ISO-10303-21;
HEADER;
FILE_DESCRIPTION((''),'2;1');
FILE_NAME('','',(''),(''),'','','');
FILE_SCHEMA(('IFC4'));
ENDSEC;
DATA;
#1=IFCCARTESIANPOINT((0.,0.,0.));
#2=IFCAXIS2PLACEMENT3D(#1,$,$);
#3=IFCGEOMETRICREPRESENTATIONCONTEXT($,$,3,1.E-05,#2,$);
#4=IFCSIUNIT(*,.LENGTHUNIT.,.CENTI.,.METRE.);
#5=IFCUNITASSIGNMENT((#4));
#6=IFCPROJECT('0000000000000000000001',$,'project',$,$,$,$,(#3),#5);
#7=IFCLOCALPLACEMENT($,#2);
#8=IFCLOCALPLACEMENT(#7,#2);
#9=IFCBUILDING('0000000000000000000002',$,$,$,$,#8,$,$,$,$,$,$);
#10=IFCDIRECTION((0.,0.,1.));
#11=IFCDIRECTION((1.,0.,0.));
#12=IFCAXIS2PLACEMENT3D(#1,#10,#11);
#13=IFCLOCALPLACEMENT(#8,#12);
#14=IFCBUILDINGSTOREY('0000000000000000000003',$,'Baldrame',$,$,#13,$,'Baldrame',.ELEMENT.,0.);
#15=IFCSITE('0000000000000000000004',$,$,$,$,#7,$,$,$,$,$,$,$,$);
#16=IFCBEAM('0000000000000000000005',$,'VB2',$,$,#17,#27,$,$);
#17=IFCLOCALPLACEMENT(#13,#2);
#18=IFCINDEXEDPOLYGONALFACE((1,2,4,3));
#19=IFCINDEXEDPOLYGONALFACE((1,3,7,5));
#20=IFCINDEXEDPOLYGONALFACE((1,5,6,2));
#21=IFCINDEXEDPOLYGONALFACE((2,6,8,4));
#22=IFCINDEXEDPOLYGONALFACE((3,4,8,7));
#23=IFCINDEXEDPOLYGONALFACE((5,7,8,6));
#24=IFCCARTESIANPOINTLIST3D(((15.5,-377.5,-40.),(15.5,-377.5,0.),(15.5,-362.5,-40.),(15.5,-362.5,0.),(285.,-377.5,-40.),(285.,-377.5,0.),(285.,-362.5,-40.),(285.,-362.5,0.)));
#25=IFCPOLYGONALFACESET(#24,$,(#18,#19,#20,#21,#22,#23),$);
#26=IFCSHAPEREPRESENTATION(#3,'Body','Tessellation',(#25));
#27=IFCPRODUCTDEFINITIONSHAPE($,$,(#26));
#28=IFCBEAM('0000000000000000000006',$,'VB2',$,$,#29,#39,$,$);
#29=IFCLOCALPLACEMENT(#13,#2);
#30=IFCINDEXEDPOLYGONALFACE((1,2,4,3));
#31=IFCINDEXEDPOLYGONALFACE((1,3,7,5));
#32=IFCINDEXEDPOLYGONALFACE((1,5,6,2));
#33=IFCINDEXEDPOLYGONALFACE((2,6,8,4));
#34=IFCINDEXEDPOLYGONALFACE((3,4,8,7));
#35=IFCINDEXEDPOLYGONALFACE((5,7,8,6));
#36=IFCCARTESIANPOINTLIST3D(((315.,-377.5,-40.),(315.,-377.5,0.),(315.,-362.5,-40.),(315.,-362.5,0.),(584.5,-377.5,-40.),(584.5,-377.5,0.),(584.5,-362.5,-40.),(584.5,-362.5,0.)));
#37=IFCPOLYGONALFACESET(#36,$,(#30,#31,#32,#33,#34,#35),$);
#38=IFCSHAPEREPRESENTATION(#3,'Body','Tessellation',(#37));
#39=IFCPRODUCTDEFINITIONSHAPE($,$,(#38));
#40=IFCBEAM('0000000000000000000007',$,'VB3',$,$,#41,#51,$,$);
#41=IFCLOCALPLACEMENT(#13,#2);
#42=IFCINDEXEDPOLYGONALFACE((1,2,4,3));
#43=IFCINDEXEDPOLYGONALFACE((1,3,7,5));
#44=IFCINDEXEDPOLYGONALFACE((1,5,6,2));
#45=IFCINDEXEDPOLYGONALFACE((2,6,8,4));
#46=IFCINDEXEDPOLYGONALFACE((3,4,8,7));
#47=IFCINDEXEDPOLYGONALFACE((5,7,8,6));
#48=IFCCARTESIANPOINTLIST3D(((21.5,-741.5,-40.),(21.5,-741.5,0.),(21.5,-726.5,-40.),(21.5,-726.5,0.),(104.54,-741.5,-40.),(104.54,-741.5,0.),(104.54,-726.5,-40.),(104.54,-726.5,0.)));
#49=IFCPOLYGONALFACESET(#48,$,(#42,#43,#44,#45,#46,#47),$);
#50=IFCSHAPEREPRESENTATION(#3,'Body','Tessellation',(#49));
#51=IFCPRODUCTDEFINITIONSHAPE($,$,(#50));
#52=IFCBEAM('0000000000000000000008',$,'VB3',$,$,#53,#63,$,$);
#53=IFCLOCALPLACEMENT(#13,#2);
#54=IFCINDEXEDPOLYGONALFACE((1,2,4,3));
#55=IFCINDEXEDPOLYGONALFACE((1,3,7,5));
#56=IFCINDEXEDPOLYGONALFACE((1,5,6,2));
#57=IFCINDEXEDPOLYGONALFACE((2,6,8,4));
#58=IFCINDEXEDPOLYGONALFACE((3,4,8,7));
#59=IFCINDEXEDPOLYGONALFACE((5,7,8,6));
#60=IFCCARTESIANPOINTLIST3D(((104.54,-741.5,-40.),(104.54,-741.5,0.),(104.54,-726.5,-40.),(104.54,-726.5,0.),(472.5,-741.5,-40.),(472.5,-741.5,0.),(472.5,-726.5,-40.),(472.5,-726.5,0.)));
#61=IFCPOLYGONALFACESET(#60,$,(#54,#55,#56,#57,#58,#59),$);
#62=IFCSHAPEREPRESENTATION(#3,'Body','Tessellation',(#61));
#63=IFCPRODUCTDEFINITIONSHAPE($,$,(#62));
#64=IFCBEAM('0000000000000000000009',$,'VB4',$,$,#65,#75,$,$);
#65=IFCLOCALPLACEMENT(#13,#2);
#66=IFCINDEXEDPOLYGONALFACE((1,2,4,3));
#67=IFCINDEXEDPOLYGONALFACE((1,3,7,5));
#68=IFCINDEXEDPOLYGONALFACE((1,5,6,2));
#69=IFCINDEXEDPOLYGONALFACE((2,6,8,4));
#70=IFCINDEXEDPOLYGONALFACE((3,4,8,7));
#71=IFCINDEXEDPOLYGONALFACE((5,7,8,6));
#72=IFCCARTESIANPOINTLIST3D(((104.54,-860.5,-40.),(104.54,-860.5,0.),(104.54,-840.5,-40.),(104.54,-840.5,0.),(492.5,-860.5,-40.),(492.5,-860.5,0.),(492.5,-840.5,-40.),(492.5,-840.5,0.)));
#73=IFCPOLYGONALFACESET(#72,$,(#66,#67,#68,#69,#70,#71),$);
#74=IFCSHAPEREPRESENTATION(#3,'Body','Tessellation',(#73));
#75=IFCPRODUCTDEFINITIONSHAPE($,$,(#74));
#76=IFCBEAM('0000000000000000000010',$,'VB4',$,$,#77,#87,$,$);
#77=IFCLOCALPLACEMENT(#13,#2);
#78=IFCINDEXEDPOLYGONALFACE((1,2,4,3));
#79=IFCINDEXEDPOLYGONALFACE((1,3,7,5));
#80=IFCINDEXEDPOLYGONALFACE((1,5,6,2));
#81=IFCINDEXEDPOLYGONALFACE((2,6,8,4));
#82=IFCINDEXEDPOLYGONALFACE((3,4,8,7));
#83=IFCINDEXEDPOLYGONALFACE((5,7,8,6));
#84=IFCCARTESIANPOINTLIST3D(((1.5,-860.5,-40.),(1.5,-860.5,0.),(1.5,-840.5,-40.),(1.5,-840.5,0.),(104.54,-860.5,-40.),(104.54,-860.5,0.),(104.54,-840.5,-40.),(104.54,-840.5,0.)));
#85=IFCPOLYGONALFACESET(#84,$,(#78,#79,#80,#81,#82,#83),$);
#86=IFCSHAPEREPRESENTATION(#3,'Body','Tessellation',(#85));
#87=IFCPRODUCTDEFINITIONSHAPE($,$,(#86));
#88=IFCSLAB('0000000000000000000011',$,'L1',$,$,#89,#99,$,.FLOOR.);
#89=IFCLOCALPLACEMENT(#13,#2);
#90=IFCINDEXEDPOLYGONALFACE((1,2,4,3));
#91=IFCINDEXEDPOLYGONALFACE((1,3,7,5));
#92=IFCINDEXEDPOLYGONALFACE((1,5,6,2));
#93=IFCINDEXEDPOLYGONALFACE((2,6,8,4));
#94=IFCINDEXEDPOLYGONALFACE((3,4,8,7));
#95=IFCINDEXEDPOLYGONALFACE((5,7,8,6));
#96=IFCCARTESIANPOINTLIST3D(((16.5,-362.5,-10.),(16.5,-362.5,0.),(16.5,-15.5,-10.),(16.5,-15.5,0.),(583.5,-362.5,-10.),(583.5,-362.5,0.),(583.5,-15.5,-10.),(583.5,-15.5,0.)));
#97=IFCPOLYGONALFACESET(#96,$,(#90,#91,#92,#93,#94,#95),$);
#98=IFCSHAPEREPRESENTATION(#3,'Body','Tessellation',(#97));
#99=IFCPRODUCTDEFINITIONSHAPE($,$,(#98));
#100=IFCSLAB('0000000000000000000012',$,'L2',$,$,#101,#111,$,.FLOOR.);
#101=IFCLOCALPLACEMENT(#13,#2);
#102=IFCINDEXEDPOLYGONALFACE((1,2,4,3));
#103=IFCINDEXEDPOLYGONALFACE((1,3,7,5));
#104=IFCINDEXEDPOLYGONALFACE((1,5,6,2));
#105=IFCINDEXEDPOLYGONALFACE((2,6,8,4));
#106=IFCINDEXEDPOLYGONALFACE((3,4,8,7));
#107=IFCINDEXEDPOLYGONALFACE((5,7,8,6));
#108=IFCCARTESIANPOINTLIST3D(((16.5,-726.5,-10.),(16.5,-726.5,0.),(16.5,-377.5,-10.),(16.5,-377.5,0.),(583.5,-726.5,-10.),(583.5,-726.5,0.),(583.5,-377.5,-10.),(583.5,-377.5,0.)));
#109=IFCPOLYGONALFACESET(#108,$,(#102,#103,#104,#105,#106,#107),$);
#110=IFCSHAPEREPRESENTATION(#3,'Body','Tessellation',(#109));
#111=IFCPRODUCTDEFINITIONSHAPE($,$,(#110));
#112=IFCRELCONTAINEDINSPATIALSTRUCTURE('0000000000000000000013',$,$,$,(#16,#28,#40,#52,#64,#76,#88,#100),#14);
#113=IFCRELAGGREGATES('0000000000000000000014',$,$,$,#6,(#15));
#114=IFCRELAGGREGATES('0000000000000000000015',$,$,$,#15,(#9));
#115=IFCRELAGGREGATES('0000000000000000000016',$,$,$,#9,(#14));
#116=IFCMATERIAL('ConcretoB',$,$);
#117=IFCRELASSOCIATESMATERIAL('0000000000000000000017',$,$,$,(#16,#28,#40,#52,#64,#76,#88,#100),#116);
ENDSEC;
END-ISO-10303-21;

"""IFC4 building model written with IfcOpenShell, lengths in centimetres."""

from ifc_helpers import new_model, si_unit, frame, origin, origin_with_axes, place, context, project, spatial, polyline, outline, extrude, material, element, save


model = new_model("IFC4")

# Units and contexts
context_of_model = context(None, 3, precision=1e-05, world=origin())
ifc_project = project(units=[si_unit("LENGTHUNIT", "METRE", prefix="CENTI")], contexts=[context_of_model])

# Site, building, storey
site_placement = place(None, origin())
site = spatial("IfcSite", under=ifc_project, at=site_placement)
building_placement = place(site_placement, origin())
building = spatial("IfcBuilding", under=site, at=building_placement)
storey_placement = place(building_placement, origin_with_axes())
storey = spatial("IfcBuildingStorey", under=building, at=storey_placement, Name="Baldrame", LongName="Baldrame", CompositionType="ELEMENT", Elevation=0.0)

# Shared definitions
ifc_material = material(Name="ConcretoB")

# Beams
for number, where, z_axis, x_axis, name in (
    (1, (150.25, -370.0, 0.0), (0.0, 0.0, 1.0), (1.0, 0.0, 0.0), "VB2"),
    (2, (449.75, -370.0, 0.0), (0.0, 0.0, 1.0), (1.0, 0.0, 0.0), "VB2"),
):
    element("IfcBeam", number, at=place(storey_placement, frame(where, z_axis=z_axis, x_axis=x_axis)), inside=storey, material=ifc_material, Name=name, context=context_of_model, shape_type="SolidModel", body=[
        extrude(outline(polyline([(-7.5, -20.0), (7.5, -20.0), (7.5, 20.0), (-7.5, 20.0), (-7.5, -20.0)])), frame((-134.75, 0.0, -20.0), z_axis=(1.0, 0.0, 0.0), x_axis=(0.0, -1.0, 0.0)), (0.0, 0.0, 1.0), 269.5),
    ])
beam_1_placement = place(storey_placement, frame((63.02, -734.0, 0.0), z_axis=(0.0, 0.0, 1.0), x_axis=(1.0, 0.0, 0.0)))
element("IfcBeam", 3, at=beam_1_placement, inside=storey, material=ifc_material, Name="VB3", context=context_of_model, shape_type="SolidModel", body=[
    extrude(outline(polyline([(-7.5, -20.0), (7.5, -20.0), (7.5, 20.0), (-7.5, 20.0), (-7.5, -20.0)])), frame((-41.52, 0.0, -20.0), z_axis=(1.0, 0.0, 0.0), x_axis=(0.0, -1.0, 0.0)), (0.0, 0.0, 1.0), 83.04),
])
beam_2_placement = place(storey_placement, frame((288.52, -734.0, 0.0), z_axis=(0.0, 0.0, 1.0), x_axis=(1.0, 0.0, 0.0)))
element("IfcBeam", 4, at=beam_2_placement, inside=storey, material=ifc_material, Name="VB3", context=context_of_model, shape_type="SolidModel", body=[
    extrude(outline(polyline([(-7.5, -20.0), (7.5, -20.0), (7.5, 20.0), (-7.5, 20.0), (-7.5, -20.0)])), frame((-183.98, 0.0, -20.0), z_axis=(1.0, 0.0, 0.0), x_axis=(0.0, -1.0, 0.0)), (0.0, 0.0, 1.0), 367.96),
])
beam_3_placement = place(storey_placement, frame((298.52, -850.5, 0.0), z_axis=(0.0, 0.0, 1.0), x_axis=(1.0, 0.0, 0.0)))
element("IfcBeam", 5, at=beam_3_placement, inside=storey, material=ifc_material, Name="VB4", context=context_of_model, shape_type="SolidModel", body=[
    extrude(outline(polyline([(-10.0, -20.0), (10.0, -20.0), (10.0, 20.0), (-10.0, 20.0), (-10.0, -20.0)])), frame((-193.98, 0.0, -20.0), z_axis=(1.0, 0.0, 0.0), x_axis=(0.0, -1.0, 0.0)), (0.0, 0.0, 1.0), 387.96),
])
beam_4_placement = place(storey_placement, frame((53.02, -850.5, 0.0), z_axis=(0.0, 0.0, 1.0), x_axis=(1.0, 0.0, 0.0)))
element("IfcBeam", 6, at=beam_4_placement, inside=storey, material=ifc_material, Name="VB4", context=context_of_model, shape_type="SolidModel", body=[
    extrude(outline(polyline([(-10.0, -20.0), (10.0, -20.0), (10.0, 20.0), (-10.0, 20.0), (-10.0, -20.0)])), frame((-51.52, 0.0, -20.0), z_axis=(1.0, 0.0, 0.0), x_axis=(0.0, -1.0, 0.0)), (0.0, 0.0, 1.0), 103.04),
])

# Slabs
slab_1_placement = place(storey_placement, frame((300.0, -189.0, 0.0), z_axis=(0.0, 0.0, 1.0), x_axis=(1.0, 0.0, 0.0)))
element("IfcSlab", 7, at=slab_1_placement, inside=storey, material=ifc_material, Name="L1", PredefinedType="FLOOR", context=context_of_model, shape_type="SolidModel", body=[
    extrude(outline(polyline([(283.5, 173.5), (-283.5, 173.5), (-283.5, -173.5), (283.5, -173.5), (283.5, 173.5), (283.5, 173.5)])), frame((0.0, 0.0, -10.0), z_axis=(0.0, 0.0, 1.0), x_axis=(1.0, 0.0, 0.0)), (0.0, 0.0, 1.0), 10.0),
])
slab_2_placement = place(storey_placement, frame((300.0, -552.0, 0.0), z_axis=(0.0, 0.0, 1.0), x_axis=(1.0, 0.0, 0.0)))
element("IfcSlab", 8, at=slab_2_placement, inside=storey, material=ifc_material, Name="L2", PredefinedType="FLOOR", context=context_of_model, shape_type="SolidModel", body=[
    extrude(outline(polyline([(283.5, 174.5), (-283.5, 174.5), (-283.5, -174.5), (283.5, -174.5), (283.5, 174.5), (283.5, 174.5)])), frame((0.0, 0.0, -10.0), z_axis=(0.0, 0.0, 1.0), x_axis=(1.0, 0.0, 0.0)), (0.0, 0.0, 1.0), 10.0),
])

save(model, "model.ifc")
